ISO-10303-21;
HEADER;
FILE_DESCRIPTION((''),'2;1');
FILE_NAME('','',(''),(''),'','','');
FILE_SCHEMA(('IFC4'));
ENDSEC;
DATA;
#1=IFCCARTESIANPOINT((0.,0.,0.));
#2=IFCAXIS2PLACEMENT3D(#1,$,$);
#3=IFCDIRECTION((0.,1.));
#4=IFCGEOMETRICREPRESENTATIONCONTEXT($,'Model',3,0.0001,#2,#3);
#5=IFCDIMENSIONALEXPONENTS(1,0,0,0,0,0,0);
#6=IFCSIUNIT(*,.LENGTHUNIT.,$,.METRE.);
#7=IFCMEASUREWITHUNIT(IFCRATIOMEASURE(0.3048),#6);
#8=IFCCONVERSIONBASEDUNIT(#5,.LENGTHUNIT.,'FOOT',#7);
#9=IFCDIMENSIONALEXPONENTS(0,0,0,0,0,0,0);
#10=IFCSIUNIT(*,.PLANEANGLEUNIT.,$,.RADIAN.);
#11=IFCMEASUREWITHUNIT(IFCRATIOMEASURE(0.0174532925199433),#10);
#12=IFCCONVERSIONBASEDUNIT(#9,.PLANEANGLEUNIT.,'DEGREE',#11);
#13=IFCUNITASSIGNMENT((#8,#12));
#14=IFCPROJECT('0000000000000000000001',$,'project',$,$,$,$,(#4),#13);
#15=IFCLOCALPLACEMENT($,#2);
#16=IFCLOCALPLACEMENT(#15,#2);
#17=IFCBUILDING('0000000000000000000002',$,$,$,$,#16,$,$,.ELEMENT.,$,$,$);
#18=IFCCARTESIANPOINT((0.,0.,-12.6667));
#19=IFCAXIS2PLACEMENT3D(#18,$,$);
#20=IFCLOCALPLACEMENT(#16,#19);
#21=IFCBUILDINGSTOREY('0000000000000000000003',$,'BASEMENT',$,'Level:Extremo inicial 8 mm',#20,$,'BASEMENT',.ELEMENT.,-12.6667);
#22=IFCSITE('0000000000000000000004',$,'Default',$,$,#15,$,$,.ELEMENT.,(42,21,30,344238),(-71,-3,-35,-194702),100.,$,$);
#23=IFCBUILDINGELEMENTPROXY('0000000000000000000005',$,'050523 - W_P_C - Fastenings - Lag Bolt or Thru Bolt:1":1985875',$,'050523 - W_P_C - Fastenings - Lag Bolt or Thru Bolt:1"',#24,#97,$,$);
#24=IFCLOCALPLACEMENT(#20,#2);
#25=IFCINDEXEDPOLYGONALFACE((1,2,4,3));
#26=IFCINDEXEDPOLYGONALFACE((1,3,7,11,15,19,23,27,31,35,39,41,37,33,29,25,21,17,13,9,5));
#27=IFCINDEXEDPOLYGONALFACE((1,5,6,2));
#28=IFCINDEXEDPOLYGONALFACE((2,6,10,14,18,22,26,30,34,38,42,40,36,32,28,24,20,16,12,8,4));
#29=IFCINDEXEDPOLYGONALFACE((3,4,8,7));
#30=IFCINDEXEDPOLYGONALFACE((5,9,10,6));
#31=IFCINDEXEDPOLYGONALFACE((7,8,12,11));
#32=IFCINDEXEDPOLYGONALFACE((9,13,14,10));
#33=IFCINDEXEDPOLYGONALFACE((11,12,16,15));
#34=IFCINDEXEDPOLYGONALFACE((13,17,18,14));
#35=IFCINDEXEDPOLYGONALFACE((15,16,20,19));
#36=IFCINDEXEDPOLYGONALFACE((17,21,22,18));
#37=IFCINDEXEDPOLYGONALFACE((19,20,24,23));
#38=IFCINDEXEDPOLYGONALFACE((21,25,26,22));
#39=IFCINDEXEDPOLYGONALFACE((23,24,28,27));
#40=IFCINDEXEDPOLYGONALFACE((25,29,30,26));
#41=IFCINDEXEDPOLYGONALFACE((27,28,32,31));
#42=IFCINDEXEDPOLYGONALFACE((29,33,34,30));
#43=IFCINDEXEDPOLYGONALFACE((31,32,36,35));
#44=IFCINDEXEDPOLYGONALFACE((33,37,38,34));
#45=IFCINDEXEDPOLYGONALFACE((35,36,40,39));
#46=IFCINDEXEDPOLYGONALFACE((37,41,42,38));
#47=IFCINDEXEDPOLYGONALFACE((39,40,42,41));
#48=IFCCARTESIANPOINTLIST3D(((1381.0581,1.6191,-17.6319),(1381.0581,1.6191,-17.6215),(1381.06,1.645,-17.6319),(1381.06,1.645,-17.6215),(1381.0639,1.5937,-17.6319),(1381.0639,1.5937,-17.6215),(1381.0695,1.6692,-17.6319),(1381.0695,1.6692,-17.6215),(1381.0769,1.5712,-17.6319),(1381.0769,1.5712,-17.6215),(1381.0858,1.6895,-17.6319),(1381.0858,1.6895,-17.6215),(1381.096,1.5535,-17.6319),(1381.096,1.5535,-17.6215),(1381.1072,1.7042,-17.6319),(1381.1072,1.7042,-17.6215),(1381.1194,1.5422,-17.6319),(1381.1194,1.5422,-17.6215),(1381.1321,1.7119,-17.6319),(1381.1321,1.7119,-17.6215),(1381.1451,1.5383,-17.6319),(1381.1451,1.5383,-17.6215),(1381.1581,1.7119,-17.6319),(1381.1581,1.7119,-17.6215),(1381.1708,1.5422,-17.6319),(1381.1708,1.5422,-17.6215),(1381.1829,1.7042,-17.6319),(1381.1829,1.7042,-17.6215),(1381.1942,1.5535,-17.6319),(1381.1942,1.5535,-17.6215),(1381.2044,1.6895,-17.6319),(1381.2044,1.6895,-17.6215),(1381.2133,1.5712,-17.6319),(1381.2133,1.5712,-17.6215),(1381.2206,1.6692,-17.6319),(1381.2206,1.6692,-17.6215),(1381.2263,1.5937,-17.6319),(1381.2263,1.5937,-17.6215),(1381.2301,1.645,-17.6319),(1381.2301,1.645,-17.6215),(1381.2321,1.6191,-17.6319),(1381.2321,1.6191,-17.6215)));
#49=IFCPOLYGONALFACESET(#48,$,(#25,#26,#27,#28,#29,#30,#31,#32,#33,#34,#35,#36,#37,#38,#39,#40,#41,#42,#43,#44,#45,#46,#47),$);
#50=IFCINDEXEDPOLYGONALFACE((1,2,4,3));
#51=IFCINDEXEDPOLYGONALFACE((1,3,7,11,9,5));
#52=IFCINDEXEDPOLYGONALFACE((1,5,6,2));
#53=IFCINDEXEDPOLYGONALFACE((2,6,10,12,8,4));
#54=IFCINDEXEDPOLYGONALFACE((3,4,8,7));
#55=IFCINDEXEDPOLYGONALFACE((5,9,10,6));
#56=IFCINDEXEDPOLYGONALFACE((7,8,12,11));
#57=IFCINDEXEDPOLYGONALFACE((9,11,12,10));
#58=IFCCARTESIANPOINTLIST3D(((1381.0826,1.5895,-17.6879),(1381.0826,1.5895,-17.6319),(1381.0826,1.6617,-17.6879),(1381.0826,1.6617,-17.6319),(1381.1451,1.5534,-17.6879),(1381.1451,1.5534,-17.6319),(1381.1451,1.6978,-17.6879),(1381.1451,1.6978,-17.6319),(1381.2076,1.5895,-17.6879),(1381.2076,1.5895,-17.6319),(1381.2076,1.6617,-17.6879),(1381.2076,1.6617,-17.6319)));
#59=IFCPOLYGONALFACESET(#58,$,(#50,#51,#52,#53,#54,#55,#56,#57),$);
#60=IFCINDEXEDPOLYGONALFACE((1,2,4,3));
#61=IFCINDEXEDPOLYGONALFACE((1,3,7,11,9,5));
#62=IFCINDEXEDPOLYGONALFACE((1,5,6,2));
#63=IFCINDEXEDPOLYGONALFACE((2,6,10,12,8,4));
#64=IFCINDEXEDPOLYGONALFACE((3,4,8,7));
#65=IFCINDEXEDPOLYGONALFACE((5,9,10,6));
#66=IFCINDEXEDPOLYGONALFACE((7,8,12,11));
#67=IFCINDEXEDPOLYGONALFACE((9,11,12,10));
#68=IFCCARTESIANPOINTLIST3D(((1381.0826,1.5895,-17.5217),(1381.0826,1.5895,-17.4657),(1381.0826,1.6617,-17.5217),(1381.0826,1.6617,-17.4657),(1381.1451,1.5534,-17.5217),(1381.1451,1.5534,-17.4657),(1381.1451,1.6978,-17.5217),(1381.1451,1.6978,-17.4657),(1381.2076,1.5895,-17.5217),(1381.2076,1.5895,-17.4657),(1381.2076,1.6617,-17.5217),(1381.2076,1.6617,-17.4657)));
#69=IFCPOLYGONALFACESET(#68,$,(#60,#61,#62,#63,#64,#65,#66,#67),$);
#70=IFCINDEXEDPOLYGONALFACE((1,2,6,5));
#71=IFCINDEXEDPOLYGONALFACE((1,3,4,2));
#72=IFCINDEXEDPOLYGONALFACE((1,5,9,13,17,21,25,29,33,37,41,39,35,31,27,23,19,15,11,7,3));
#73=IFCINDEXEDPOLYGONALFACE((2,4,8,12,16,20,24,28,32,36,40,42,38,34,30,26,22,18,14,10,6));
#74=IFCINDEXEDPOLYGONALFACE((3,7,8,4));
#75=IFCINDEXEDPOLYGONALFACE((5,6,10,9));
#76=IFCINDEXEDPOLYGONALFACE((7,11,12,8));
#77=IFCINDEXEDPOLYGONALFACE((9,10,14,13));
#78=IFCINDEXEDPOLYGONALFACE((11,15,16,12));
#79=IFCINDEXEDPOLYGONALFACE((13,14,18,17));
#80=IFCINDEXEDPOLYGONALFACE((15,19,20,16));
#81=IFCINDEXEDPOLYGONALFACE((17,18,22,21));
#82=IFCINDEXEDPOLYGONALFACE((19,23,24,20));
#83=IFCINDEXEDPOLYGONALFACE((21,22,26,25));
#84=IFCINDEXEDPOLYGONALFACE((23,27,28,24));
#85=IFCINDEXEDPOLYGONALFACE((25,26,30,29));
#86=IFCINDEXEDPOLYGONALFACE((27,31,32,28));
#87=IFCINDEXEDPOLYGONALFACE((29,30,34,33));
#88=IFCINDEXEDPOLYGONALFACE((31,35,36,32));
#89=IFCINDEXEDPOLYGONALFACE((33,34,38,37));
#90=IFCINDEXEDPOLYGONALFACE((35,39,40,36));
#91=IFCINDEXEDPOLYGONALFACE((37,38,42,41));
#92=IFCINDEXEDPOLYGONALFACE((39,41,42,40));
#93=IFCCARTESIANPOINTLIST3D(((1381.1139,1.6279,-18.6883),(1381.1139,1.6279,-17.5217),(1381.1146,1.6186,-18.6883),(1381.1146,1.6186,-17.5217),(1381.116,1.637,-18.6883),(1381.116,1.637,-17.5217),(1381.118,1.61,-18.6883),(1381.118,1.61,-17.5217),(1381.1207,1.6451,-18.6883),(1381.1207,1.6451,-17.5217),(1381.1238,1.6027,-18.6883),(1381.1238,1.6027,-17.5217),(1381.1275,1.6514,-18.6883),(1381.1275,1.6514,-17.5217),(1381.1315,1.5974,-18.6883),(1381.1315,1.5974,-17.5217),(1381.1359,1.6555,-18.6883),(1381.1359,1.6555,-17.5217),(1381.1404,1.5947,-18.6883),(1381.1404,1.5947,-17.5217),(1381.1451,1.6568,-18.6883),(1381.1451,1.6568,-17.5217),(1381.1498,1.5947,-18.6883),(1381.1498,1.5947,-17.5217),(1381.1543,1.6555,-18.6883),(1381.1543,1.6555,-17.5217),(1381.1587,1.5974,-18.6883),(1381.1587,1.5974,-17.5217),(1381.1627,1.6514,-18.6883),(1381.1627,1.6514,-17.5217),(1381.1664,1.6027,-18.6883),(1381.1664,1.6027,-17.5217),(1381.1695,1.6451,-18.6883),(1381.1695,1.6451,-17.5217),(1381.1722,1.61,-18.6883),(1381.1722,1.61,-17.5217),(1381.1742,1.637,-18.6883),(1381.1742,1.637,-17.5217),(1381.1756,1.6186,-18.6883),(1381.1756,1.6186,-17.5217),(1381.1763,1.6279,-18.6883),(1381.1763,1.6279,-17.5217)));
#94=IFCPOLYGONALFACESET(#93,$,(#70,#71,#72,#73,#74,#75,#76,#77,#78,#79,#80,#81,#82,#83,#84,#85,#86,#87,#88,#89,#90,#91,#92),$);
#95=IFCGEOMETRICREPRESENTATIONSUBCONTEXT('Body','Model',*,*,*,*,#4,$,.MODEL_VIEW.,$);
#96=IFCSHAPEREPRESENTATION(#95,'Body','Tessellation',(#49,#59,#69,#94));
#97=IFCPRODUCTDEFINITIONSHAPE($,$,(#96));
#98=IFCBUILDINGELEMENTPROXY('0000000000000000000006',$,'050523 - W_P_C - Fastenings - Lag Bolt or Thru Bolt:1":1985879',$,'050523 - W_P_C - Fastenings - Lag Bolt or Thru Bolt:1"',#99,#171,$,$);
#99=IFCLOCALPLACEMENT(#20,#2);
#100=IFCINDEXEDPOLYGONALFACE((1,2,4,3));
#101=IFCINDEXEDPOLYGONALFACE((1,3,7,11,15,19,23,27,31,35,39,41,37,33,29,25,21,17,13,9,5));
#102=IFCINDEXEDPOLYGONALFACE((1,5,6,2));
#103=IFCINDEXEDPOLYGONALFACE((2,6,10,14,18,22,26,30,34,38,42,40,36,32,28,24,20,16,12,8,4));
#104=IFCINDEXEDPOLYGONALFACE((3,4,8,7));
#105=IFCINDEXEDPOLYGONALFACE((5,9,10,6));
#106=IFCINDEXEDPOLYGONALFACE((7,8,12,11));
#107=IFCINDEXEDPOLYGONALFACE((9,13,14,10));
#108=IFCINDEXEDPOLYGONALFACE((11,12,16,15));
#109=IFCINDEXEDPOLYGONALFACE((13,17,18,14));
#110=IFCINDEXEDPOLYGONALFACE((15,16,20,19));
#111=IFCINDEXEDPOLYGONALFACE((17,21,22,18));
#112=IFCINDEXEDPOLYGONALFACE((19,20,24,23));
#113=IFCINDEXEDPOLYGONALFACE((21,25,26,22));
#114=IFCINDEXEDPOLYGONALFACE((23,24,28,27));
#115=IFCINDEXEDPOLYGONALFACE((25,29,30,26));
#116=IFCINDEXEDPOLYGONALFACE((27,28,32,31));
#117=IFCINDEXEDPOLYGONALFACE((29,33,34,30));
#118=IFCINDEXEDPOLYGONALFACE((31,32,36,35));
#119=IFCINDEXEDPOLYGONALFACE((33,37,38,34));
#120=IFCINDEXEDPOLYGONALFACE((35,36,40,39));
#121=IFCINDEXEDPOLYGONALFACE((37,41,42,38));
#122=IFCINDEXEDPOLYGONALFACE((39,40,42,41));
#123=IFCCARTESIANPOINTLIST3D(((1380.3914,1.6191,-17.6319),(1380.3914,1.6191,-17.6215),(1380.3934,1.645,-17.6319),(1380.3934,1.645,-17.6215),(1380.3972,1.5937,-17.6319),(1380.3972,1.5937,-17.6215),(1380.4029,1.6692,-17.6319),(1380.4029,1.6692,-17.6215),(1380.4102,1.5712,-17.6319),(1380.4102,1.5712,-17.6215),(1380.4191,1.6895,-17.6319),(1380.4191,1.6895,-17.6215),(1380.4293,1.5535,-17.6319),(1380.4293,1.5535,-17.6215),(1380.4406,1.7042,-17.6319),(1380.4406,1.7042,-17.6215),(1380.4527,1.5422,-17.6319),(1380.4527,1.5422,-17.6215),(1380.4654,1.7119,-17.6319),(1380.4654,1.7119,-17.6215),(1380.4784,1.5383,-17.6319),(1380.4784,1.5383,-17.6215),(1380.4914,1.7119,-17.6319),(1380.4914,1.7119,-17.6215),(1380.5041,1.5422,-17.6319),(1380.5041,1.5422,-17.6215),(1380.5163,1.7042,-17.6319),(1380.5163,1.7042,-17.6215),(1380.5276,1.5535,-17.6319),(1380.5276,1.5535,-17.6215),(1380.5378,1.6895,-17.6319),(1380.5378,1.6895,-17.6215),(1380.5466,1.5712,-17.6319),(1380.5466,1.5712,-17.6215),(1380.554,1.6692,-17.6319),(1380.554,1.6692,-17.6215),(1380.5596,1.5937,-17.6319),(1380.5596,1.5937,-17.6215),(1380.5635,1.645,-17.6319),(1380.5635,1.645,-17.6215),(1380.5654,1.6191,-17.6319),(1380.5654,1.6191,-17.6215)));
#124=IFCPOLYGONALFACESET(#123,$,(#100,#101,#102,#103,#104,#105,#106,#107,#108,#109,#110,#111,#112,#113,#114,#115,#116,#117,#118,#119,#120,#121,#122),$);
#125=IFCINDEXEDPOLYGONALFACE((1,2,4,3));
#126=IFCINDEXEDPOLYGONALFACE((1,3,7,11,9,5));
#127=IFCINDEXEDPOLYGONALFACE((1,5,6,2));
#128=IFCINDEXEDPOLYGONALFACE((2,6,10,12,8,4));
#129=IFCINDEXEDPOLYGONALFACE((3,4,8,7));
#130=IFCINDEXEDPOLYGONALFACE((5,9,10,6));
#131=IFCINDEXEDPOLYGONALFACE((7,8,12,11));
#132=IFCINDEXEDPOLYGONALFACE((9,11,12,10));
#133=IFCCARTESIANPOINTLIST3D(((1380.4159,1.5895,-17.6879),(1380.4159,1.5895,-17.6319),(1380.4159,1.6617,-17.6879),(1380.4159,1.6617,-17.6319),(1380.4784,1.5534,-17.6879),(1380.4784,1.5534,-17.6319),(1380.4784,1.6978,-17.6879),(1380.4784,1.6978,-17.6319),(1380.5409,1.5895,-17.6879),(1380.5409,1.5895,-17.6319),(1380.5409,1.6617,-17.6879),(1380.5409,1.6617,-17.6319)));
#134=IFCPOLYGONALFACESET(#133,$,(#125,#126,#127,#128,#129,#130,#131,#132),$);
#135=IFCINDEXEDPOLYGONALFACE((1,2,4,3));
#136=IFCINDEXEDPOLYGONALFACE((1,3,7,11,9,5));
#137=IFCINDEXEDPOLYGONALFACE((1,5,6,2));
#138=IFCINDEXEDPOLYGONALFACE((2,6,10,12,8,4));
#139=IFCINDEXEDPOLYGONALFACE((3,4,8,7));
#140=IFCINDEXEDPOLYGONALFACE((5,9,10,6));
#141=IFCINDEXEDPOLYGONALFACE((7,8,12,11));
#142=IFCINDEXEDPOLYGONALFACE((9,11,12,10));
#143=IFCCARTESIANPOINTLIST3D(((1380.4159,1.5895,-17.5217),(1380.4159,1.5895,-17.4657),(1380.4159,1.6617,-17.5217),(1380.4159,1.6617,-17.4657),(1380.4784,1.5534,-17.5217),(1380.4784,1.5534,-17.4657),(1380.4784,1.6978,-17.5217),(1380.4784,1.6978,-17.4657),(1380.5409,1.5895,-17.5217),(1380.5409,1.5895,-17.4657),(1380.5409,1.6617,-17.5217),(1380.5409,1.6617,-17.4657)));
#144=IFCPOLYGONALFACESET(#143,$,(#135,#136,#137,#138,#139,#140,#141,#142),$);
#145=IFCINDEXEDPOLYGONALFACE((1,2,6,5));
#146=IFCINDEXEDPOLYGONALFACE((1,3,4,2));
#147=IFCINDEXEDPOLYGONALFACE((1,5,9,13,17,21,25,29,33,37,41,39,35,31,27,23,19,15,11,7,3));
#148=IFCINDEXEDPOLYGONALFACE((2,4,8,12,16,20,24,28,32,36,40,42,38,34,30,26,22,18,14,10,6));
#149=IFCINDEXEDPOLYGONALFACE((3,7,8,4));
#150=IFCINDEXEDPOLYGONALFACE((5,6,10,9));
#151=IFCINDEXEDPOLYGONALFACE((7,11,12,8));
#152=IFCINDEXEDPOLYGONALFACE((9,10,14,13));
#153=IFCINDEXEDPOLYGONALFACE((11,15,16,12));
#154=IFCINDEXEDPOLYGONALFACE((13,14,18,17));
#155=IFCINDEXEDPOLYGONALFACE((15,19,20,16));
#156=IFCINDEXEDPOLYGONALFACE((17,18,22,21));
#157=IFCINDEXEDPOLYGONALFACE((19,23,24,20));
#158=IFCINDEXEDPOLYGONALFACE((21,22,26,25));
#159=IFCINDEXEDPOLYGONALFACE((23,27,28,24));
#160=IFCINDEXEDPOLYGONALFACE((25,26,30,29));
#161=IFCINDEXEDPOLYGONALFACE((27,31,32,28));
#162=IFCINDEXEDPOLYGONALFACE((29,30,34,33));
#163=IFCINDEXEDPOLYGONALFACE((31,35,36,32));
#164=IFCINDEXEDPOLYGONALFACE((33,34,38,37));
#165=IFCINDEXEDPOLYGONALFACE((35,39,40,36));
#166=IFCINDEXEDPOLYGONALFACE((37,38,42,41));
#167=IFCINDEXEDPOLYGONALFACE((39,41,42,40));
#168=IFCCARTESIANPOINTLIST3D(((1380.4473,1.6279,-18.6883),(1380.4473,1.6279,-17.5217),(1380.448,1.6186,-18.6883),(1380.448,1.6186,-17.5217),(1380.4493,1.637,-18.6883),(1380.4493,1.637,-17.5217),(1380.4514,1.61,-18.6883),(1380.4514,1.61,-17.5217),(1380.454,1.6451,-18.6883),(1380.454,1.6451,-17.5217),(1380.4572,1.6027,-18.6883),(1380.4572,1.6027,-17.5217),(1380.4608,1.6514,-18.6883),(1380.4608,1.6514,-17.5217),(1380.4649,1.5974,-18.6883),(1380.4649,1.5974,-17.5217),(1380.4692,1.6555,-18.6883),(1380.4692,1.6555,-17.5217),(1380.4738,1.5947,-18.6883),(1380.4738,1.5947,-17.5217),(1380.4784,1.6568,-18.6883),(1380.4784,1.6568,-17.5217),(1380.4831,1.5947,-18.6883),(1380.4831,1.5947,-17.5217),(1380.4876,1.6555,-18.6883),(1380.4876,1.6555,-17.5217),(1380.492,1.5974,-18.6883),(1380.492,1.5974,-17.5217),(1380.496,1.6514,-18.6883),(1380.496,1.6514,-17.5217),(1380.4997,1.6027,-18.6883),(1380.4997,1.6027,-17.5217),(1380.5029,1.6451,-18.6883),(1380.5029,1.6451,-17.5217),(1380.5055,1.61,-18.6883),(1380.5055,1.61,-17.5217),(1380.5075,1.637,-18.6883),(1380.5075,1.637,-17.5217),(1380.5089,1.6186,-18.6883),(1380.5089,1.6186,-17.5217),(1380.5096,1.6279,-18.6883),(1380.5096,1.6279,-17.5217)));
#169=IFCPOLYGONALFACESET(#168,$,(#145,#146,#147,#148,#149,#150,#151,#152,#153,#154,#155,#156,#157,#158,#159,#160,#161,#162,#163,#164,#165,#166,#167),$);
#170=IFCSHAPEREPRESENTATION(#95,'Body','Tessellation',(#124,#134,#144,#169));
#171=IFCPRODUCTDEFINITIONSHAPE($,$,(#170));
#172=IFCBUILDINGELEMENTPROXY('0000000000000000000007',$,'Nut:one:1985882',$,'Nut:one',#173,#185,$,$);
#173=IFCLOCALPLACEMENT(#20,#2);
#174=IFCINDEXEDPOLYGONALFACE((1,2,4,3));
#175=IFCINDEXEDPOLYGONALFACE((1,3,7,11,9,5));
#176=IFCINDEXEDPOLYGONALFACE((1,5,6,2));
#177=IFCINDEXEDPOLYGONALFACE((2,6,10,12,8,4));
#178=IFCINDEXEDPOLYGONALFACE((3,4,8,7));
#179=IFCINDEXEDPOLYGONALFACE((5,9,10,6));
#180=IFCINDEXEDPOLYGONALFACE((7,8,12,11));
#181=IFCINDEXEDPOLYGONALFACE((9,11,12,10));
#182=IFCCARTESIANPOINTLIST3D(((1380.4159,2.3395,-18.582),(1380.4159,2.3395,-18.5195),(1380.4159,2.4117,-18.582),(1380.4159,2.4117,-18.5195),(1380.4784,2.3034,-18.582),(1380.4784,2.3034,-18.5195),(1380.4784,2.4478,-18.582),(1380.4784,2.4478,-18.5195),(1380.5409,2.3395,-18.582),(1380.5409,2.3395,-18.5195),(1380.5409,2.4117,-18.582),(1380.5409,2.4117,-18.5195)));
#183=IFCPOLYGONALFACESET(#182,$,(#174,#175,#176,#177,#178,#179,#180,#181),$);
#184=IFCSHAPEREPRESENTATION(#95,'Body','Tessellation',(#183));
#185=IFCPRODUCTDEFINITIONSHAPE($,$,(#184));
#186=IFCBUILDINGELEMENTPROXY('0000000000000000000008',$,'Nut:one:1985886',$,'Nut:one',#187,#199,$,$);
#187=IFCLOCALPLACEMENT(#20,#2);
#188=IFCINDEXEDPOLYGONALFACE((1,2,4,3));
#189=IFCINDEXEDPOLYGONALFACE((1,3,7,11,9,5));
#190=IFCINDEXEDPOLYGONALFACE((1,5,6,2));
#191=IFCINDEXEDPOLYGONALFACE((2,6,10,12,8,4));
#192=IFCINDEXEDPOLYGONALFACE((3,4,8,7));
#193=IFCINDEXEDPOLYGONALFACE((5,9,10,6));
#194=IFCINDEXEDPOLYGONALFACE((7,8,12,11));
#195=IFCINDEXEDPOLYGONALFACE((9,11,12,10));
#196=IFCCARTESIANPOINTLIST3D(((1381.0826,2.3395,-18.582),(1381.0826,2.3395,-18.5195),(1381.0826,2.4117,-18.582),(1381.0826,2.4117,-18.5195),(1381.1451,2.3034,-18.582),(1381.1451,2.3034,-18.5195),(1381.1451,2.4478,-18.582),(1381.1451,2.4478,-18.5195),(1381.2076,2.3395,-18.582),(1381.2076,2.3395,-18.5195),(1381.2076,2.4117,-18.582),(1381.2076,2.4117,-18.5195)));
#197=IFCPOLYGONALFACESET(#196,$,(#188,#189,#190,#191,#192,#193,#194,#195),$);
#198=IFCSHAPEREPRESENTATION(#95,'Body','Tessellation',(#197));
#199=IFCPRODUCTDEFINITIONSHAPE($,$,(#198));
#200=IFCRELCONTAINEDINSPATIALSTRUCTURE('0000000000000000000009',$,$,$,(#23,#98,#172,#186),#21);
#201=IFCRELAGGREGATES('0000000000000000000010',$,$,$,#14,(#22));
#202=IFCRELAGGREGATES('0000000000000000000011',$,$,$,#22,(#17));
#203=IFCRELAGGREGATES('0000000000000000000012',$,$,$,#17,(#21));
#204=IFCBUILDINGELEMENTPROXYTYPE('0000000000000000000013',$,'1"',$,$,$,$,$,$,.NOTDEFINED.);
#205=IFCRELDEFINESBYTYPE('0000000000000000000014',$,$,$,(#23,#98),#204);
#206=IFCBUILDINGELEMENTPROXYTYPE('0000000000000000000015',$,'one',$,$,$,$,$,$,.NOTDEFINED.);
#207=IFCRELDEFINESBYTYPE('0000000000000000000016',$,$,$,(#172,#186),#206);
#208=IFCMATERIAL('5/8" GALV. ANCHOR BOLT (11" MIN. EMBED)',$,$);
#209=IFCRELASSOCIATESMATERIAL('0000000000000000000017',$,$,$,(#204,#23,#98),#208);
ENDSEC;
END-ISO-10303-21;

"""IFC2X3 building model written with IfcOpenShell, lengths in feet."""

from ifc_helpers import new_model, entity, si_unit, converted_unit, direction, frame, frame_2d, origin, place, context, subcontext, project, spatial, polyline, circle, outline, extrude, source, transform, mapped, material, type_object, type_shapes, element, save


model = new_model("IFC2X3")

# Units and contexts
model_context = context("Model", 3, precision=0.0001, world=origin(), true_north=direction((0.0, 1.0)))
body_context = subcontext(model_context, "Body", "Model", "MODEL_VIEW")
ifc_project = project(units=[converted_unit("LENGTHUNIT", "FOOT", entity("IfcRatioMeasure", 0.3048), si_unit("LENGTHUNIT", "METRE"), dimensions=[1, 0, 0, 0, 0, 0, 0]), converted_unit("PLANEANGLEUNIT", "DEGREE", entity("IfcRatioMeasure", 0.0174532925199433), si_unit("PLANEANGLEUNIT", "RADIAN"), dimensions=[0, 0, 0, 0, 0, 0, 0])], contexts=[model_context])

# Site, building, storey
site_placement = place(None, origin())
site = spatial("IfcSite", under=ifc_project, at=site_placement, Name="Default", CompositionType="ELEMENT", RefLatitude=(42, 21, 30, 344238), RefLongitude=(-71, -3, -35, -194702), RefElevation=100.0)
building_placement = place(site_placement, origin())
building = spatial("IfcBuilding", under=site, at=building_placement, CompositionType="ELEMENT")
storey_placement = place(building_placement, frame((0.0, 0.0, -12.6667)))
storey = spatial("IfcBuildingStorey", under=building, at=storey_placement, Name="BASEMENT", ObjectType="Level:Extremo inicial 8 mm", LongName="BASEMENT", CompositionType="ELEMENT", Elevation=-12.6667)

# Building element proxies
ifc_material_1 = material(Name="5/8\" GALV. ANCHOR BOLT (11\" MIN. EMBED)")
building_element_proxy_type_1 = type_object("IfcBuildingElementProxyType", Name="1\"", PredefinedType="NOTDEFINED", material=ifc_material_1)
shared_shape_1 = source(origin(), body_context, "Body", "SweptSolid", [
    extrude(circle(Radius=0.0872, at=frame_2d((0.0, 0.0), x_axis=(1.0, 0.0))), frame((0.0, 0.0, -0.1102), z_axis=(0.0, 0.0, 1.0), x_axis=(0.0, -1.0, 0.0)), (0.0, 0.0, 1.0), 0.0104),
    extrude(outline(polyline([(-0.0361, -0.0625), (0.0361, -0.0625), (0.0722, 0.0), (0.0361, 0.0625), (-0.0361, 0.0625), (-0.0722, 0.0), (-0.0361, -0.0625)])), frame((0.0, 0.0, -0.1662), z_axis=(0.0, 0.0, 1.0), x_axis=(0.866025, -0.5, 0.0)), (0.0, 0.0, 1.0), 0.056),
    extrude(outline(polyline([(-0.0361, -0.0625), (0.0361, -0.0625), (0.0722, 0.0), (0.0361, 0.0625), (-0.0361, 0.0625), (-0.0722, 0.0), (-0.0361, -0.0625)])), frame((0.0, 0.0, 0.0), z_axis=(0.0, 0.0, 1.0), x_axis=(0.0, -1.0, 0.0)), (0.0, 0.0, 1.0), 0.056),
    extrude(circle(Radius=0.0312, at=frame_2d((0.0, 0.0), x_axis=(1.0, 0.0))), frame((0.0, 0.0, -1.1667), z_axis=(0.0, 0.0, 1.0), x_axis=(0.0, 1.0, 0.0)), (0.0, 0.0, 1.0), 1.1667),
])
type_shapes(building_element_proxy_type_1, [shared_shape_1])
for number, where, name in (
    (1, (1381.1451, 1.6256, -17.5217), "050523 - W_P_C - Fastenings - Lag Bolt or Thru Bolt:1\":1985875"),
    (2, (1380.4784, 1.6256, -17.5217), "050523 - W_P_C - Fastenings - Lag Bolt or Thru Bolt:1\":1985879"),
):
    element("IfcBuildingElementProxy", number, at=place(storey_placement, frame(where)), inside=storey, type_object=building_element_proxy_type_1, material=ifc_material_1, Name=name, ObjectType="050523 - W_P_C - Fastenings - Lag Bolt or Thru Bolt:1\"", context=body_context, shape_type="MappedRepresentation", body=[
        mapped(shared_shape_1, transform((0.0, 0.0, 0.0), scale=1.0)),
    ])
building_element_proxy_type_2 = type_object("IfcBuildingElementProxyType", Name="one", PredefinedType="NOTDEFINED")
shared_shape_2 = source(origin(), body_context, "Body", "SweptSolid", [
    extrude(outline(polyline([(-0.0361, -0.0625), (0.0361, -0.0625), (0.0722, 0.0), (0.0361, 0.0625), (-0.0361, 0.0625), (-0.0722, 0.0), (-0.0361, -0.0625)])), frame((0.0, 0.0, 0.0), z_axis=(0.0, 0.0, 1.0), x_axis=(0.866025, -0.5, 0.0)), (0.0, 0.0, 1.0), 0.0625),
])
type_shapes(building_element_proxy_type_2, [shared_shape_2])
for number, where, z_axis, x_axis, name in (
    (3, (1380.4784, 2.3756, -18.5195), (0.0, 0.0, -1.0), (1.0, 0.0, 0.0), "Nut:one:1985882"),
    (4, (1381.1451, 2.3756, -18.5195), (0.0, 0.0, -1.0), (1.0, 0.0, 0.0), "Nut:one:1985886"),
):
    element("IfcBuildingElementProxy", number, at=place(storey_placement, frame(where, z_axis=z_axis, x_axis=x_axis)), inside=storey, type_object=building_element_proxy_type_2, Name=name, ObjectType="Nut:one", context=body_context, shape_type="MappedRepresentation", body=[
        mapped(shared_shape_2, transform((0.0, 0.0, 0.0), scale=1.0)),
    ])

save(model, "model.ifc")
